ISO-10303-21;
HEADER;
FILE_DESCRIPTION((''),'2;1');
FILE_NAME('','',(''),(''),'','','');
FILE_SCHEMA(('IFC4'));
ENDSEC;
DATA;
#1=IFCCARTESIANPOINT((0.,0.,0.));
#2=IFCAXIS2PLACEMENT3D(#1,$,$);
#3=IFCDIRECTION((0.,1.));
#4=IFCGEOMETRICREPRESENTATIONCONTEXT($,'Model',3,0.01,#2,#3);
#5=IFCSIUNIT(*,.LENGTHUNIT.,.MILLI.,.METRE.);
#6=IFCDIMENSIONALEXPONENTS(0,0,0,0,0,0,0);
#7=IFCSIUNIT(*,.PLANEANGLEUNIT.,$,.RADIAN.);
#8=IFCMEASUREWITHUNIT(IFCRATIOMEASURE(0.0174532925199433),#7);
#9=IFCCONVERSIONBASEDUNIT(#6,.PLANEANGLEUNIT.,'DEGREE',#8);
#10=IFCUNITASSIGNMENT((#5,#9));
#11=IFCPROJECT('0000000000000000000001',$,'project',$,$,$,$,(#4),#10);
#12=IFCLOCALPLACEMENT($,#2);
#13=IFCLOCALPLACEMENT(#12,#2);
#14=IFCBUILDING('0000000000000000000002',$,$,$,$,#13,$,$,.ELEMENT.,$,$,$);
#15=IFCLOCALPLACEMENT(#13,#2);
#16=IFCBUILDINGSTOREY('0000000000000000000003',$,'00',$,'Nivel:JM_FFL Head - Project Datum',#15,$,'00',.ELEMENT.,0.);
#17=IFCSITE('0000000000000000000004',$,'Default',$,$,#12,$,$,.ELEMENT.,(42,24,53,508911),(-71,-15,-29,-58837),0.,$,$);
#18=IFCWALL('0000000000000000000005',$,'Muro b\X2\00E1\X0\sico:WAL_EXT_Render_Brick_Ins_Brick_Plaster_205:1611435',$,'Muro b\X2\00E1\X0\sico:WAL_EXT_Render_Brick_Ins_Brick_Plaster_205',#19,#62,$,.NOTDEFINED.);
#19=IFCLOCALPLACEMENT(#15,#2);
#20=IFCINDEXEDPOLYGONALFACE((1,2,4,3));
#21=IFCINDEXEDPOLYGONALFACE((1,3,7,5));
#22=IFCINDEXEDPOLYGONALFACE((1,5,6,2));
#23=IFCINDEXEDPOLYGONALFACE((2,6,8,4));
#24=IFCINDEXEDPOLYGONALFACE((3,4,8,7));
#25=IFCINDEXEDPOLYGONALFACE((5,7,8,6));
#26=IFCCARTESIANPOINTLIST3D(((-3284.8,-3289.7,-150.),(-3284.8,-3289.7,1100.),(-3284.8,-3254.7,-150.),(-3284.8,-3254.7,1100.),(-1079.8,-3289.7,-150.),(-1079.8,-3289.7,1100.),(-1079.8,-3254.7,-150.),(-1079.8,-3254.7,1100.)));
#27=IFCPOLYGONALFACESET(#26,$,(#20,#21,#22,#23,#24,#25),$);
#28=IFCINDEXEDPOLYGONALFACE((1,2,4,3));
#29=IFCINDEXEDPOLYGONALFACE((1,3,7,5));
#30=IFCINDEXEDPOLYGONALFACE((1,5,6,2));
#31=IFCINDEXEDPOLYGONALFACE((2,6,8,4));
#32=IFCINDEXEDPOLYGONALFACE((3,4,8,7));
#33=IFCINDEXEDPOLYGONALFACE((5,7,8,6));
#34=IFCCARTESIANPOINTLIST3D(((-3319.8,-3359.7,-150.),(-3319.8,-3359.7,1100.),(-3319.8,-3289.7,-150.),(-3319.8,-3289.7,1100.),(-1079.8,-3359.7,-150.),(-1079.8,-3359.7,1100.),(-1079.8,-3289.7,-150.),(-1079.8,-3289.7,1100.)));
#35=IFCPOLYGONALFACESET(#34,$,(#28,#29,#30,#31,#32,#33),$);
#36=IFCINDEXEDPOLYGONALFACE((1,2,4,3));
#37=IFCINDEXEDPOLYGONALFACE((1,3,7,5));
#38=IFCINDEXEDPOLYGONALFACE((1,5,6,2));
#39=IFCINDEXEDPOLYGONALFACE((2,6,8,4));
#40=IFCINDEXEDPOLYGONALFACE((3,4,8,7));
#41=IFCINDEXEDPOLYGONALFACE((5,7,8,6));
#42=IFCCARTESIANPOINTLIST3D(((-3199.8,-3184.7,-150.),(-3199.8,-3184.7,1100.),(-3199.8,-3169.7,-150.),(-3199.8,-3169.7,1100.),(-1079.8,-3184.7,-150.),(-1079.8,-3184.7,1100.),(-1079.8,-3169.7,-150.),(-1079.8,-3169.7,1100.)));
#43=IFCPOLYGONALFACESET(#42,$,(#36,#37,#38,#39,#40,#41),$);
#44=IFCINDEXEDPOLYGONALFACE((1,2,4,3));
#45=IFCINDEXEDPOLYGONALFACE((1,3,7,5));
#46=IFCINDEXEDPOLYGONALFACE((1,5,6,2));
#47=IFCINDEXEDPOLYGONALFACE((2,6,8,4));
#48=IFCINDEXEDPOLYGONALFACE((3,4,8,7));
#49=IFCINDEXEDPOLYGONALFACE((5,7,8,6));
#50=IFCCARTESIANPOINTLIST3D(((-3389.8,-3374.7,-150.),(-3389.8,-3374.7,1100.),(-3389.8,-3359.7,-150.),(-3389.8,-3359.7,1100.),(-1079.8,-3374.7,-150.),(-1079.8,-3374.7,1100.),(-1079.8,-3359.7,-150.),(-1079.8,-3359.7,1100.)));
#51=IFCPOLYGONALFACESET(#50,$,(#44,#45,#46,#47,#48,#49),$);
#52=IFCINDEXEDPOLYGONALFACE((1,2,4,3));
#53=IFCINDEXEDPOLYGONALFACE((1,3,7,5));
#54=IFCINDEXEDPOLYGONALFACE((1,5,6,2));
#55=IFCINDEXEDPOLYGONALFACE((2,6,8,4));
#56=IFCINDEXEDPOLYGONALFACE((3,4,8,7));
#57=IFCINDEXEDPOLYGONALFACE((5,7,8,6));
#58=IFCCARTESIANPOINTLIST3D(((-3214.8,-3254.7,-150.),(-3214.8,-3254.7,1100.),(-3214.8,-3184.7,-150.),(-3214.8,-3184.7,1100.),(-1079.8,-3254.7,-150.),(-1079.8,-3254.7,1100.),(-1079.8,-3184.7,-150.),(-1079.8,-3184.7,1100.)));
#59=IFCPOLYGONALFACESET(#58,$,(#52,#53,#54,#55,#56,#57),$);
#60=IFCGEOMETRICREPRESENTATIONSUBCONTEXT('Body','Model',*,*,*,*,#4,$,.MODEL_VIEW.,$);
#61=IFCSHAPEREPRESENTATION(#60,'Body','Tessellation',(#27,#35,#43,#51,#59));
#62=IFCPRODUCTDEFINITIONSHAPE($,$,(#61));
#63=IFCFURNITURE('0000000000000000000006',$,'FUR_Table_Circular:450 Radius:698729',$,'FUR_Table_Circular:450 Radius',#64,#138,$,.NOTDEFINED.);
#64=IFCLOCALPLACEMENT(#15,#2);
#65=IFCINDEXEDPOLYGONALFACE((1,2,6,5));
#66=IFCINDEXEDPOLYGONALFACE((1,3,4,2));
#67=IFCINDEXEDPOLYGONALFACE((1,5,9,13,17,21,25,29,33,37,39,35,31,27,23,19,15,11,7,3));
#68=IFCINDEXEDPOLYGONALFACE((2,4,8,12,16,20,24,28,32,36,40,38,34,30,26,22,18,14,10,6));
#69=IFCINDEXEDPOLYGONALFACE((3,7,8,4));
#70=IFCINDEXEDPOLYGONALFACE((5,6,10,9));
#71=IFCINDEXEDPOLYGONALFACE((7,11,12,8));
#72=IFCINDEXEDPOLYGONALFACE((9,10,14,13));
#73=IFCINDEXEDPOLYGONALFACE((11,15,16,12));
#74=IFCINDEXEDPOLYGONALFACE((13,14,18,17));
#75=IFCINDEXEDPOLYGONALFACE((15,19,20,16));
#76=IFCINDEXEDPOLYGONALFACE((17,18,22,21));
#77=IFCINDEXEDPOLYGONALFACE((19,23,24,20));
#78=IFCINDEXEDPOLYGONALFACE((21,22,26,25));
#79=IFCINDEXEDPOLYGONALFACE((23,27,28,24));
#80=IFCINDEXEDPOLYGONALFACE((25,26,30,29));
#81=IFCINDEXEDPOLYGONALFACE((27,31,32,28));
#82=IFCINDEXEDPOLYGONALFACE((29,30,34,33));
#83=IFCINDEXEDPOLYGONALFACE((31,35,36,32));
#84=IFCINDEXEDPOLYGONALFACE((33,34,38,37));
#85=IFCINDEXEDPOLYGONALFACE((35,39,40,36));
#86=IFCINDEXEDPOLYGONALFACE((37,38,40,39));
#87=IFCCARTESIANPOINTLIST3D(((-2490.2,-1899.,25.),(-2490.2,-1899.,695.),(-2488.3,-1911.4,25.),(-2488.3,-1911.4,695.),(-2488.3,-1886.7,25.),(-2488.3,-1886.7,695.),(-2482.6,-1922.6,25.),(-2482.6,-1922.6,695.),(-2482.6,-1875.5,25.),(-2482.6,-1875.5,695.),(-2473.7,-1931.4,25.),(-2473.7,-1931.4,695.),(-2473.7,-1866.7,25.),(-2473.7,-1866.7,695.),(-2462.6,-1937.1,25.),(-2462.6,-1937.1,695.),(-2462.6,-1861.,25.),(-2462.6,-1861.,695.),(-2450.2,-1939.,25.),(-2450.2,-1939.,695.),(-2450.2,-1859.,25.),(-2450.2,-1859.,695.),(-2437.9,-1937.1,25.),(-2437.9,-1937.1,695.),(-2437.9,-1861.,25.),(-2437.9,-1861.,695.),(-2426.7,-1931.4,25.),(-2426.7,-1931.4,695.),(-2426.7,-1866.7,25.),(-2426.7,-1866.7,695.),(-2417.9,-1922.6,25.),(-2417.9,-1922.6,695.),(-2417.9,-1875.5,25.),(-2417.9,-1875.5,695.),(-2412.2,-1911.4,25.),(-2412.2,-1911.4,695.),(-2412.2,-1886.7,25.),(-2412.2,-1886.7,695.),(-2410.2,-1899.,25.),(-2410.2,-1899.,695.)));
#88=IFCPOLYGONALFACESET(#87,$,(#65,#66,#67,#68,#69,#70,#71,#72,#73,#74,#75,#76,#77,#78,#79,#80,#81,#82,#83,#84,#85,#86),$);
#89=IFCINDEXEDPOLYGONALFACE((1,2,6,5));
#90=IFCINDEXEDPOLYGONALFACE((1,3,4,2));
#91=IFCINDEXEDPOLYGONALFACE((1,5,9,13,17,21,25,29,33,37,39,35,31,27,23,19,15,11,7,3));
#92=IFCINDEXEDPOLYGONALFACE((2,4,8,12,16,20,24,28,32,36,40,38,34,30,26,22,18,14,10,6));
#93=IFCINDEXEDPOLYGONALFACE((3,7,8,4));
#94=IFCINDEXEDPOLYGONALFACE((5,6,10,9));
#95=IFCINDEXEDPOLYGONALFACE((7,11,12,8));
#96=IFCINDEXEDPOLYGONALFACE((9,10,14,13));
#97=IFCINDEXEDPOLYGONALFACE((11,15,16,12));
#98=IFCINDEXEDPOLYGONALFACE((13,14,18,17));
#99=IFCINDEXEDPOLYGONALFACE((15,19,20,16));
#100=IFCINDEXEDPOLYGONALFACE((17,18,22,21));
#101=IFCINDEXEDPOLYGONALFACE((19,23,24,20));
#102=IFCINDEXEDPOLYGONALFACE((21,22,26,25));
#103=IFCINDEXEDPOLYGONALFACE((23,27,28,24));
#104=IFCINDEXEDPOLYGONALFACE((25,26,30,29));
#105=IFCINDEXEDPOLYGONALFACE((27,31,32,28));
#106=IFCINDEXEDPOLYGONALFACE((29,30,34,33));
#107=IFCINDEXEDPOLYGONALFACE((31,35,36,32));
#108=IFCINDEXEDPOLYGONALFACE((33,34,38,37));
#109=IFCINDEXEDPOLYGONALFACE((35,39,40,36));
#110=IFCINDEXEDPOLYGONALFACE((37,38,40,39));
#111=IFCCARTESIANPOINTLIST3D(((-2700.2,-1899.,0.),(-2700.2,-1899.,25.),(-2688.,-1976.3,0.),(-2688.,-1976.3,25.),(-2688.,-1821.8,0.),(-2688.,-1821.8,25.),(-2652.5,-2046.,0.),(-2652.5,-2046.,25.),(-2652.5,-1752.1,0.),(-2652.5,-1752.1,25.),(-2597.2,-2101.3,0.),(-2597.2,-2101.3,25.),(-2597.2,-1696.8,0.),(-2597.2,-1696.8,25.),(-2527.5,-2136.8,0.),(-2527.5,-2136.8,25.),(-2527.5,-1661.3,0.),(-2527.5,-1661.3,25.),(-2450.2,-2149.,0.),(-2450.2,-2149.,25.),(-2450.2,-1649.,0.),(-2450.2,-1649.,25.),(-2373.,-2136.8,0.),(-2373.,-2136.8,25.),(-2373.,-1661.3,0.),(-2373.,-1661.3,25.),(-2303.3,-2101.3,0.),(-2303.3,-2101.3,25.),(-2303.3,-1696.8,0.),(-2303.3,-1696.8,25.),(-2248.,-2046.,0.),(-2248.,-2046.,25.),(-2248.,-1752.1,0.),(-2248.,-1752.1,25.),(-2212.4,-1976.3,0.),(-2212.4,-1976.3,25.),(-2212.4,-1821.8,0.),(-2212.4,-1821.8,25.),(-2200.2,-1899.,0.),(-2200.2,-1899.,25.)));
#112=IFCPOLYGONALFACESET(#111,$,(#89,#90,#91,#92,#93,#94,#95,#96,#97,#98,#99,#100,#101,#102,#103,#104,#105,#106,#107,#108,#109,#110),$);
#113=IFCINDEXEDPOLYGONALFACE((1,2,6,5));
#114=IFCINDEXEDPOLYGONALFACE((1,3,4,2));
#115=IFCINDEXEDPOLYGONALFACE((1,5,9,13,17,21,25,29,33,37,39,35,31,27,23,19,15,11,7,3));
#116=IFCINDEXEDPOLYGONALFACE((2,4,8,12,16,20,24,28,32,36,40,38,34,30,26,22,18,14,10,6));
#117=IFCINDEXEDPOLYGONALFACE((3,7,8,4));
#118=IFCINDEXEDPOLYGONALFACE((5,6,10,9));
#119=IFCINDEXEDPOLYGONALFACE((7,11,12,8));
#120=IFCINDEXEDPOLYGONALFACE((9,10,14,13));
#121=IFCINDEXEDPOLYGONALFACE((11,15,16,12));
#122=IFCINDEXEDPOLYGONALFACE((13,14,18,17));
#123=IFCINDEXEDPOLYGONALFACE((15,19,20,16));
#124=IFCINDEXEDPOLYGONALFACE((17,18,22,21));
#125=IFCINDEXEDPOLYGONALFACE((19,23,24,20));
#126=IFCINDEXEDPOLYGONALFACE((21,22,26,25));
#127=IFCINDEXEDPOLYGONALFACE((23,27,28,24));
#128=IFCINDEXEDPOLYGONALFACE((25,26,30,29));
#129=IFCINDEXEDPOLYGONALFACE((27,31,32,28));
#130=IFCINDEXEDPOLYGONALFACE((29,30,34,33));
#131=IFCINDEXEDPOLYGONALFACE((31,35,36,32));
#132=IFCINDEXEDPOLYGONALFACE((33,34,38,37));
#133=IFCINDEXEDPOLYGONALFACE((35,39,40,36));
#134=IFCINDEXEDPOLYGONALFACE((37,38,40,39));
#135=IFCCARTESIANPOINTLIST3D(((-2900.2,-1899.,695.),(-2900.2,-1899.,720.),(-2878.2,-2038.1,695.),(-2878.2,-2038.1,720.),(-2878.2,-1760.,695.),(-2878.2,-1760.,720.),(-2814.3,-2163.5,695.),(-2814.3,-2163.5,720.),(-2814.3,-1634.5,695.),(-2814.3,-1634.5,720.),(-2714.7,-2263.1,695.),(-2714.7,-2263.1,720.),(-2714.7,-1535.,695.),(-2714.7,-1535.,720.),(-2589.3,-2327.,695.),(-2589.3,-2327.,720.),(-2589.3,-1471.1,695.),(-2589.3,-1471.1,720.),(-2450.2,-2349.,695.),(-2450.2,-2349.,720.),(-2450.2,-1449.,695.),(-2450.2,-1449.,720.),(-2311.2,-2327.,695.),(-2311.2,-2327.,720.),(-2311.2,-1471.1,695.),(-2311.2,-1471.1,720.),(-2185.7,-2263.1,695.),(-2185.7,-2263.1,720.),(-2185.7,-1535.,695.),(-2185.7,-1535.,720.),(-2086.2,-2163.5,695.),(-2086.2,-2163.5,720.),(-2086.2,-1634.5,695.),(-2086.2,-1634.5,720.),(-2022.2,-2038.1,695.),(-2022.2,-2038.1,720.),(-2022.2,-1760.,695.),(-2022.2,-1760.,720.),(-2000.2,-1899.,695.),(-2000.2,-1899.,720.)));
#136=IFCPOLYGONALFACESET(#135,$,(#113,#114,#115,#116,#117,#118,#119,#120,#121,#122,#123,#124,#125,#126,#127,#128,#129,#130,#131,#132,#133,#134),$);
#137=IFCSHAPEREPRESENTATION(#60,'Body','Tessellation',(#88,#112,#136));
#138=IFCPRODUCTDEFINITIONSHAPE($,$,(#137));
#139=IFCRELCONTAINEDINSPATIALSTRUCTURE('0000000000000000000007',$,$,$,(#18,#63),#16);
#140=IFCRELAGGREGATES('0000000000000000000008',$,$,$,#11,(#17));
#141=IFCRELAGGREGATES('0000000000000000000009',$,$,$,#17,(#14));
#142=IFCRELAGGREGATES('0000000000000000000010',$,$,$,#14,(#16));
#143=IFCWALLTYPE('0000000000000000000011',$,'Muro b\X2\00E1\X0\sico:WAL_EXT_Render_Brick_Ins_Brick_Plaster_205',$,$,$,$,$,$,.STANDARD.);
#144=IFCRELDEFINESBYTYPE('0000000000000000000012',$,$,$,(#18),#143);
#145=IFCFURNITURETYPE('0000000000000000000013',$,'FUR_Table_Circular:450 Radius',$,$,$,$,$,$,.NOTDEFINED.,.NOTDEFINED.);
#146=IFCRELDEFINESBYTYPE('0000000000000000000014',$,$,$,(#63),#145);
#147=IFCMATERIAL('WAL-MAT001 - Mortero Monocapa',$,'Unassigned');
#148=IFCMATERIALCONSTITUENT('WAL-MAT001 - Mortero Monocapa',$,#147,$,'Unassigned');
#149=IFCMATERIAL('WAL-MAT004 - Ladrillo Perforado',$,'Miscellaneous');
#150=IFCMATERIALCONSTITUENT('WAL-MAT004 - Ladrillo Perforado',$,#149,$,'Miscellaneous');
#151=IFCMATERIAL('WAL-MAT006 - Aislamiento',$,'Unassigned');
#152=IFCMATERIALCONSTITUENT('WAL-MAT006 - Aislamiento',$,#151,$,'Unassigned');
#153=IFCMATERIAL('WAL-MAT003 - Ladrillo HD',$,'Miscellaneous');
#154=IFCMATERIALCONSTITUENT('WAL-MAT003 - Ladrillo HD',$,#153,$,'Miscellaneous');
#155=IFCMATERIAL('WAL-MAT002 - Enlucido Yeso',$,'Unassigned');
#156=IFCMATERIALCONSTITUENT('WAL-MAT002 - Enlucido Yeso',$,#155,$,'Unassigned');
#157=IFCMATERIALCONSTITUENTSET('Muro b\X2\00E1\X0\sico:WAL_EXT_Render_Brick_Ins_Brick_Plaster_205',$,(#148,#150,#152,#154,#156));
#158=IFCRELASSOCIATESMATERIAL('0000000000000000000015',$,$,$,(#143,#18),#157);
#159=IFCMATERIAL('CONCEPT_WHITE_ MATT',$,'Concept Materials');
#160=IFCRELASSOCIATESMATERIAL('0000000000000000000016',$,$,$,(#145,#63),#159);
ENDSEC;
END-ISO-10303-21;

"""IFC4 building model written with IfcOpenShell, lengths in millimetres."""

from ifc_helpers import new_model, entity, si_unit, converted_unit, direction, frame, origin, place, context, subcontext, project, spatial, indexed_curve, outline, extrude, source, transform, mapped, material, constituent, constituent_set, type_object, type_shapes, element, save


model = new_model("IFC4")

# Units and contexts
model_context = context("Model", 3, precision=0.01, world=origin(), true_north=direction((0.0, 1.0)))
body_context = subcontext(model_context, "Body", "Model", "MODEL_VIEW")
ifc_project = project(units=[si_unit("LENGTHUNIT", "METRE", prefix="MILLI"), converted_unit("PLANEANGLEUNIT", "DEGREE", entity("IfcRatioMeasure", 0.0174532925199433), si_unit("PLANEANGLEUNIT", "RADIAN"), dimensions=[0, 0, 0, 0, 0, 0, 0])], contexts=[model_context])

# Site, building, storey
site_placement = place(None, origin())
site = spatial("IfcSite", under=ifc_project, at=site_placement, Name="Default", CompositionType="ELEMENT", RefLatitude=(42, 24, 53, 508911), RefLongitude=(-71, -15, -29, -58837), RefElevation=0.0)
building_placement = place(site_placement, origin())
building = spatial("IfcBuilding", under=site, at=building_placement, CompositionType="ELEMENT")
storey_placement = place(building_placement, origin())
storey = spatial("IfcBuildingStorey", under=building, at=storey_placement, Name="00", ObjectType="Nivel:JM_FFL Head - Project Datum", LongName="00", CompositionType="ELEMENT", Elevation=0.0)

# Shared definitions
ifc_material_1 = material(Name="CONCEPT_WHITE_ MATT", Category="Concept Materials")

# Wall
ifc_material_2 = material(Name="WAL-MAT001 - Mortero Monocapa", Category="Unassigned")
ifc_constituent_1 = constituent(ifc_material_2, Name="WAL-MAT001 - Mortero Monocapa", Category="Unassigned")
ifc_material_3 = material(Name="WAL-MAT004 - Ladrillo Perforado", Category="Miscellaneous")
ifc_constituent_2 = constituent(ifc_material_3, Name="WAL-MAT004 - Ladrillo Perforado", Category="Miscellaneous")
ifc_material_4 = material(Name="WAL-MAT006 - Aislamiento", Category="Unassigned")
ifc_constituent_3 = constituent(ifc_material_4, Name="WAL-MAT006 - Aislamiento", Category="Unassigned")
ifc_material_5 = material(Name="WAL-MAT003 - Ladrillo HD", Category="Miscellaneous")
ifc_constituent_4 = constituent(ifc_material_5, Name="WAL-MAT003 - Ladrillo HD", Category="Miscellaneous")
ifc_material_6 = material(Name="WAL-MAT002 - Enlucido Yeso", Category="Unassigned")
ifc_constituent_5 = constituent(ifc_material_6, Name="WAL-MAT002 - Enlucido Yeso", Category="Unassigned")
ifc_constituent_set = constituent_set(constituents=[ifc_constituent_1, ifc_constituent_2, ifc_constituent_3, ifc_constituent_4, ifc_constituent_5], Name="Muro básico:WAL_EXT_Render_Brick_Ins_Brick_Plaster_205")
wall_type = type_object("IfcWallType", Name="Muro básico:WAL_EXT_Render_Brick_Ins_Brick_Plaster_205", PredefinedType="STANDARD", material=ifc_constituent_set)
wall_1_placement = place(storey_placement, frame((-3199.8, -3272.2, -150.0)))
element("IfcWall", 1, at=wall_1_placement, inside=storey, type_object=wall_type, material=ifc_constituent_set, Name="Muro básico:WAL_EXT_Render_Brick_Ins_Brick_Plaster_205:1611435", ObjectType="Muro básico:WAL_EXT_Render_Brick_Ins_Brick_Plaster_205", PredefinedType="NOTDEFINED", context=body_context, shape_type="SweptSolid", body=[
    extrude(outline(indexed_curve([(-1102.5, -17.5), (1102.5, -17.5), (1102.5, 17.5), (-1102.5, 17.5), (-1102.5, -17.5)], self_intersect=False)), frame((1017.5, 0.0, 0.0)), (0.0, 0.0, 1.0), 1250.0),
    extrude(outline(indexed_curve([(-1120.0, -35.0), (1120.0, -35.0), (1120.0, 35.0), (-1120.0, 35.0), (-1120.0, -35.0)], self_intersect=False)), frame((1000.0, -52.5, 0.0)), (0.0, 0.0, 1.0), 1250.0),
    extrude(outline(indexed_curve([(-7.5, -1060.0), (7.5, -1060.0), (7.5, 1060.0), (-7.5, 1060.0), (-7.5, -1060.0)], self_intersect=False)), frame((1060.0, 95.0, 0.0), z_axis=(0.0, 0.0, 1.0), x_axis=(0.0, -1.0, 0.0)), (0.0, 0.0, 1.0), 1250.0),
    extrude(outline(indexed_curve([(-7.5, -1155.0), (7.5, -1155.0), (7.5, 1155.0), (-7.5, 1155.0), (-7.5, -1155.0)], self_intersect=False)), frame((965.0, -95.0, 0.0), z_axis=(0.0, 0.0, 1.0), x_axis=(0.0, 1.0, 0.0)), (0.0, 0.0, 1.0), 1250.0),
    extrude(outline(indexed_curve([(-1067.5, -35.0), (1067.5, -35.0), (1067.5, 35.0), (-1067.5, 35.0), (-1067.5, -35.0)], self_intersect=False)), frame((1052.5, 52.5, 0.0)), (0.0, 0.0, 1.0), 1250.0),
])

# Furniture
furniture_type = type_object("IfcFurnitureType", Name="FUR_Table_Circular:450 Radius", AssemblyPlace="NOTDEFINED", PredefinedType="NOTDEFINED", material=ifc_material_1)
shared_shape_1 = source(origin(), body_context, "Body", "SweptSolid", [
    extrude(outline(indexed_curve([(40.0, 0.0), (38.0, 12.4), (32.4, 23.5), (23.5, 32.4), (12.4, 38.0), (0.0, 40.0), (-12.4, 38.0), (-23.5, 32.4), (-32.4, 23.5), (-38.0, 12.4), (-40.0, 0.0), (-38.0, -12.4), (-32.4, -23.5), (-23.5, -32.4), (-12.4, -38.0), (0.0, -40.0), (12.4, -38.0), (23.5, -32.4), (32.4, -23.5), (38.0, -12.4), (40.0, 0.0)], self_intersect=False)), frame((0.0, 0.0, 25.0)), (0.0, 0.0, 1.0), 670.0),
    extrude(outline(indexed_curve([(250.0, 0.0), (237.8, 77.3), (202.3, 146.9), (146.9, 202.3), (77.3, 237.8), (0.0, 250.0), (-77.3, 237.8), (-146.9, 202.3), (-202.3, 146.9), (-237.8, 77.3), (-250.0, 0.0), (-237.8, -77.3), (-202.3, -146.9), (-146.9, -202.3), (-77.3, -237.8), (0.0, -250.0), (77.3, -237.8), (146.9, -202.3), (202.3, -146.9), (237.8, -77.3), (250.0, 0.0)], self_intersect=False)), origin(), (0.0, 0.0, 1.0), 25.0),
    extrude(outline(indexed_curve([(450.0, 0.0), (428.0, 139.1), (364.1, 264.5), (264.5, 364.1), (139.1, 428.0), (0.0, 450.0), (-139.1, 428.0), (-264.5, 364.1), (-364.1, 264.5), (-428.0, 139.1), (-450.0, 0.0), (-428.0, -139.1), (-364.1, -264.5), (-264.5, -364.1), (-139.1, -428.0), (0.0, -450.0), (139.1, -428.0), (264.5, -364.1), (364.1, -264.5), (428.0, -139.1), (450.0, 0.0)], self_intersect=False)), frame((0.0, 0.0, 695.0)), (0.0, 0.0, 1.0), 25.0),
])
type_shapes(furniture_type, [shared_shape_1])
furniture_placement = place(storey_placement, frame((-2450.2, -1899.0, 0.0), z_axis=(0.0, 0.0, 1.0), x_axis=(0.0, -1.0, 0.0)))
element("IfcFurniture", 2, at=furniture_placement, inside=storey, type_object=furniture_type, material=ifc_material_1, Name="FUR_Table_Circular:450 Radius:698729", ObjectType="FUR_Table_Circular:450 Radius", PredefinedType="NOTDEFINED", context=body_context, shape_type="MappedRepresentation", body=[
    mapped(shared_shape_1, transform((0.0, 0.0, 0.0), scale=1.0)),
])

save(model, "model.ifc")
